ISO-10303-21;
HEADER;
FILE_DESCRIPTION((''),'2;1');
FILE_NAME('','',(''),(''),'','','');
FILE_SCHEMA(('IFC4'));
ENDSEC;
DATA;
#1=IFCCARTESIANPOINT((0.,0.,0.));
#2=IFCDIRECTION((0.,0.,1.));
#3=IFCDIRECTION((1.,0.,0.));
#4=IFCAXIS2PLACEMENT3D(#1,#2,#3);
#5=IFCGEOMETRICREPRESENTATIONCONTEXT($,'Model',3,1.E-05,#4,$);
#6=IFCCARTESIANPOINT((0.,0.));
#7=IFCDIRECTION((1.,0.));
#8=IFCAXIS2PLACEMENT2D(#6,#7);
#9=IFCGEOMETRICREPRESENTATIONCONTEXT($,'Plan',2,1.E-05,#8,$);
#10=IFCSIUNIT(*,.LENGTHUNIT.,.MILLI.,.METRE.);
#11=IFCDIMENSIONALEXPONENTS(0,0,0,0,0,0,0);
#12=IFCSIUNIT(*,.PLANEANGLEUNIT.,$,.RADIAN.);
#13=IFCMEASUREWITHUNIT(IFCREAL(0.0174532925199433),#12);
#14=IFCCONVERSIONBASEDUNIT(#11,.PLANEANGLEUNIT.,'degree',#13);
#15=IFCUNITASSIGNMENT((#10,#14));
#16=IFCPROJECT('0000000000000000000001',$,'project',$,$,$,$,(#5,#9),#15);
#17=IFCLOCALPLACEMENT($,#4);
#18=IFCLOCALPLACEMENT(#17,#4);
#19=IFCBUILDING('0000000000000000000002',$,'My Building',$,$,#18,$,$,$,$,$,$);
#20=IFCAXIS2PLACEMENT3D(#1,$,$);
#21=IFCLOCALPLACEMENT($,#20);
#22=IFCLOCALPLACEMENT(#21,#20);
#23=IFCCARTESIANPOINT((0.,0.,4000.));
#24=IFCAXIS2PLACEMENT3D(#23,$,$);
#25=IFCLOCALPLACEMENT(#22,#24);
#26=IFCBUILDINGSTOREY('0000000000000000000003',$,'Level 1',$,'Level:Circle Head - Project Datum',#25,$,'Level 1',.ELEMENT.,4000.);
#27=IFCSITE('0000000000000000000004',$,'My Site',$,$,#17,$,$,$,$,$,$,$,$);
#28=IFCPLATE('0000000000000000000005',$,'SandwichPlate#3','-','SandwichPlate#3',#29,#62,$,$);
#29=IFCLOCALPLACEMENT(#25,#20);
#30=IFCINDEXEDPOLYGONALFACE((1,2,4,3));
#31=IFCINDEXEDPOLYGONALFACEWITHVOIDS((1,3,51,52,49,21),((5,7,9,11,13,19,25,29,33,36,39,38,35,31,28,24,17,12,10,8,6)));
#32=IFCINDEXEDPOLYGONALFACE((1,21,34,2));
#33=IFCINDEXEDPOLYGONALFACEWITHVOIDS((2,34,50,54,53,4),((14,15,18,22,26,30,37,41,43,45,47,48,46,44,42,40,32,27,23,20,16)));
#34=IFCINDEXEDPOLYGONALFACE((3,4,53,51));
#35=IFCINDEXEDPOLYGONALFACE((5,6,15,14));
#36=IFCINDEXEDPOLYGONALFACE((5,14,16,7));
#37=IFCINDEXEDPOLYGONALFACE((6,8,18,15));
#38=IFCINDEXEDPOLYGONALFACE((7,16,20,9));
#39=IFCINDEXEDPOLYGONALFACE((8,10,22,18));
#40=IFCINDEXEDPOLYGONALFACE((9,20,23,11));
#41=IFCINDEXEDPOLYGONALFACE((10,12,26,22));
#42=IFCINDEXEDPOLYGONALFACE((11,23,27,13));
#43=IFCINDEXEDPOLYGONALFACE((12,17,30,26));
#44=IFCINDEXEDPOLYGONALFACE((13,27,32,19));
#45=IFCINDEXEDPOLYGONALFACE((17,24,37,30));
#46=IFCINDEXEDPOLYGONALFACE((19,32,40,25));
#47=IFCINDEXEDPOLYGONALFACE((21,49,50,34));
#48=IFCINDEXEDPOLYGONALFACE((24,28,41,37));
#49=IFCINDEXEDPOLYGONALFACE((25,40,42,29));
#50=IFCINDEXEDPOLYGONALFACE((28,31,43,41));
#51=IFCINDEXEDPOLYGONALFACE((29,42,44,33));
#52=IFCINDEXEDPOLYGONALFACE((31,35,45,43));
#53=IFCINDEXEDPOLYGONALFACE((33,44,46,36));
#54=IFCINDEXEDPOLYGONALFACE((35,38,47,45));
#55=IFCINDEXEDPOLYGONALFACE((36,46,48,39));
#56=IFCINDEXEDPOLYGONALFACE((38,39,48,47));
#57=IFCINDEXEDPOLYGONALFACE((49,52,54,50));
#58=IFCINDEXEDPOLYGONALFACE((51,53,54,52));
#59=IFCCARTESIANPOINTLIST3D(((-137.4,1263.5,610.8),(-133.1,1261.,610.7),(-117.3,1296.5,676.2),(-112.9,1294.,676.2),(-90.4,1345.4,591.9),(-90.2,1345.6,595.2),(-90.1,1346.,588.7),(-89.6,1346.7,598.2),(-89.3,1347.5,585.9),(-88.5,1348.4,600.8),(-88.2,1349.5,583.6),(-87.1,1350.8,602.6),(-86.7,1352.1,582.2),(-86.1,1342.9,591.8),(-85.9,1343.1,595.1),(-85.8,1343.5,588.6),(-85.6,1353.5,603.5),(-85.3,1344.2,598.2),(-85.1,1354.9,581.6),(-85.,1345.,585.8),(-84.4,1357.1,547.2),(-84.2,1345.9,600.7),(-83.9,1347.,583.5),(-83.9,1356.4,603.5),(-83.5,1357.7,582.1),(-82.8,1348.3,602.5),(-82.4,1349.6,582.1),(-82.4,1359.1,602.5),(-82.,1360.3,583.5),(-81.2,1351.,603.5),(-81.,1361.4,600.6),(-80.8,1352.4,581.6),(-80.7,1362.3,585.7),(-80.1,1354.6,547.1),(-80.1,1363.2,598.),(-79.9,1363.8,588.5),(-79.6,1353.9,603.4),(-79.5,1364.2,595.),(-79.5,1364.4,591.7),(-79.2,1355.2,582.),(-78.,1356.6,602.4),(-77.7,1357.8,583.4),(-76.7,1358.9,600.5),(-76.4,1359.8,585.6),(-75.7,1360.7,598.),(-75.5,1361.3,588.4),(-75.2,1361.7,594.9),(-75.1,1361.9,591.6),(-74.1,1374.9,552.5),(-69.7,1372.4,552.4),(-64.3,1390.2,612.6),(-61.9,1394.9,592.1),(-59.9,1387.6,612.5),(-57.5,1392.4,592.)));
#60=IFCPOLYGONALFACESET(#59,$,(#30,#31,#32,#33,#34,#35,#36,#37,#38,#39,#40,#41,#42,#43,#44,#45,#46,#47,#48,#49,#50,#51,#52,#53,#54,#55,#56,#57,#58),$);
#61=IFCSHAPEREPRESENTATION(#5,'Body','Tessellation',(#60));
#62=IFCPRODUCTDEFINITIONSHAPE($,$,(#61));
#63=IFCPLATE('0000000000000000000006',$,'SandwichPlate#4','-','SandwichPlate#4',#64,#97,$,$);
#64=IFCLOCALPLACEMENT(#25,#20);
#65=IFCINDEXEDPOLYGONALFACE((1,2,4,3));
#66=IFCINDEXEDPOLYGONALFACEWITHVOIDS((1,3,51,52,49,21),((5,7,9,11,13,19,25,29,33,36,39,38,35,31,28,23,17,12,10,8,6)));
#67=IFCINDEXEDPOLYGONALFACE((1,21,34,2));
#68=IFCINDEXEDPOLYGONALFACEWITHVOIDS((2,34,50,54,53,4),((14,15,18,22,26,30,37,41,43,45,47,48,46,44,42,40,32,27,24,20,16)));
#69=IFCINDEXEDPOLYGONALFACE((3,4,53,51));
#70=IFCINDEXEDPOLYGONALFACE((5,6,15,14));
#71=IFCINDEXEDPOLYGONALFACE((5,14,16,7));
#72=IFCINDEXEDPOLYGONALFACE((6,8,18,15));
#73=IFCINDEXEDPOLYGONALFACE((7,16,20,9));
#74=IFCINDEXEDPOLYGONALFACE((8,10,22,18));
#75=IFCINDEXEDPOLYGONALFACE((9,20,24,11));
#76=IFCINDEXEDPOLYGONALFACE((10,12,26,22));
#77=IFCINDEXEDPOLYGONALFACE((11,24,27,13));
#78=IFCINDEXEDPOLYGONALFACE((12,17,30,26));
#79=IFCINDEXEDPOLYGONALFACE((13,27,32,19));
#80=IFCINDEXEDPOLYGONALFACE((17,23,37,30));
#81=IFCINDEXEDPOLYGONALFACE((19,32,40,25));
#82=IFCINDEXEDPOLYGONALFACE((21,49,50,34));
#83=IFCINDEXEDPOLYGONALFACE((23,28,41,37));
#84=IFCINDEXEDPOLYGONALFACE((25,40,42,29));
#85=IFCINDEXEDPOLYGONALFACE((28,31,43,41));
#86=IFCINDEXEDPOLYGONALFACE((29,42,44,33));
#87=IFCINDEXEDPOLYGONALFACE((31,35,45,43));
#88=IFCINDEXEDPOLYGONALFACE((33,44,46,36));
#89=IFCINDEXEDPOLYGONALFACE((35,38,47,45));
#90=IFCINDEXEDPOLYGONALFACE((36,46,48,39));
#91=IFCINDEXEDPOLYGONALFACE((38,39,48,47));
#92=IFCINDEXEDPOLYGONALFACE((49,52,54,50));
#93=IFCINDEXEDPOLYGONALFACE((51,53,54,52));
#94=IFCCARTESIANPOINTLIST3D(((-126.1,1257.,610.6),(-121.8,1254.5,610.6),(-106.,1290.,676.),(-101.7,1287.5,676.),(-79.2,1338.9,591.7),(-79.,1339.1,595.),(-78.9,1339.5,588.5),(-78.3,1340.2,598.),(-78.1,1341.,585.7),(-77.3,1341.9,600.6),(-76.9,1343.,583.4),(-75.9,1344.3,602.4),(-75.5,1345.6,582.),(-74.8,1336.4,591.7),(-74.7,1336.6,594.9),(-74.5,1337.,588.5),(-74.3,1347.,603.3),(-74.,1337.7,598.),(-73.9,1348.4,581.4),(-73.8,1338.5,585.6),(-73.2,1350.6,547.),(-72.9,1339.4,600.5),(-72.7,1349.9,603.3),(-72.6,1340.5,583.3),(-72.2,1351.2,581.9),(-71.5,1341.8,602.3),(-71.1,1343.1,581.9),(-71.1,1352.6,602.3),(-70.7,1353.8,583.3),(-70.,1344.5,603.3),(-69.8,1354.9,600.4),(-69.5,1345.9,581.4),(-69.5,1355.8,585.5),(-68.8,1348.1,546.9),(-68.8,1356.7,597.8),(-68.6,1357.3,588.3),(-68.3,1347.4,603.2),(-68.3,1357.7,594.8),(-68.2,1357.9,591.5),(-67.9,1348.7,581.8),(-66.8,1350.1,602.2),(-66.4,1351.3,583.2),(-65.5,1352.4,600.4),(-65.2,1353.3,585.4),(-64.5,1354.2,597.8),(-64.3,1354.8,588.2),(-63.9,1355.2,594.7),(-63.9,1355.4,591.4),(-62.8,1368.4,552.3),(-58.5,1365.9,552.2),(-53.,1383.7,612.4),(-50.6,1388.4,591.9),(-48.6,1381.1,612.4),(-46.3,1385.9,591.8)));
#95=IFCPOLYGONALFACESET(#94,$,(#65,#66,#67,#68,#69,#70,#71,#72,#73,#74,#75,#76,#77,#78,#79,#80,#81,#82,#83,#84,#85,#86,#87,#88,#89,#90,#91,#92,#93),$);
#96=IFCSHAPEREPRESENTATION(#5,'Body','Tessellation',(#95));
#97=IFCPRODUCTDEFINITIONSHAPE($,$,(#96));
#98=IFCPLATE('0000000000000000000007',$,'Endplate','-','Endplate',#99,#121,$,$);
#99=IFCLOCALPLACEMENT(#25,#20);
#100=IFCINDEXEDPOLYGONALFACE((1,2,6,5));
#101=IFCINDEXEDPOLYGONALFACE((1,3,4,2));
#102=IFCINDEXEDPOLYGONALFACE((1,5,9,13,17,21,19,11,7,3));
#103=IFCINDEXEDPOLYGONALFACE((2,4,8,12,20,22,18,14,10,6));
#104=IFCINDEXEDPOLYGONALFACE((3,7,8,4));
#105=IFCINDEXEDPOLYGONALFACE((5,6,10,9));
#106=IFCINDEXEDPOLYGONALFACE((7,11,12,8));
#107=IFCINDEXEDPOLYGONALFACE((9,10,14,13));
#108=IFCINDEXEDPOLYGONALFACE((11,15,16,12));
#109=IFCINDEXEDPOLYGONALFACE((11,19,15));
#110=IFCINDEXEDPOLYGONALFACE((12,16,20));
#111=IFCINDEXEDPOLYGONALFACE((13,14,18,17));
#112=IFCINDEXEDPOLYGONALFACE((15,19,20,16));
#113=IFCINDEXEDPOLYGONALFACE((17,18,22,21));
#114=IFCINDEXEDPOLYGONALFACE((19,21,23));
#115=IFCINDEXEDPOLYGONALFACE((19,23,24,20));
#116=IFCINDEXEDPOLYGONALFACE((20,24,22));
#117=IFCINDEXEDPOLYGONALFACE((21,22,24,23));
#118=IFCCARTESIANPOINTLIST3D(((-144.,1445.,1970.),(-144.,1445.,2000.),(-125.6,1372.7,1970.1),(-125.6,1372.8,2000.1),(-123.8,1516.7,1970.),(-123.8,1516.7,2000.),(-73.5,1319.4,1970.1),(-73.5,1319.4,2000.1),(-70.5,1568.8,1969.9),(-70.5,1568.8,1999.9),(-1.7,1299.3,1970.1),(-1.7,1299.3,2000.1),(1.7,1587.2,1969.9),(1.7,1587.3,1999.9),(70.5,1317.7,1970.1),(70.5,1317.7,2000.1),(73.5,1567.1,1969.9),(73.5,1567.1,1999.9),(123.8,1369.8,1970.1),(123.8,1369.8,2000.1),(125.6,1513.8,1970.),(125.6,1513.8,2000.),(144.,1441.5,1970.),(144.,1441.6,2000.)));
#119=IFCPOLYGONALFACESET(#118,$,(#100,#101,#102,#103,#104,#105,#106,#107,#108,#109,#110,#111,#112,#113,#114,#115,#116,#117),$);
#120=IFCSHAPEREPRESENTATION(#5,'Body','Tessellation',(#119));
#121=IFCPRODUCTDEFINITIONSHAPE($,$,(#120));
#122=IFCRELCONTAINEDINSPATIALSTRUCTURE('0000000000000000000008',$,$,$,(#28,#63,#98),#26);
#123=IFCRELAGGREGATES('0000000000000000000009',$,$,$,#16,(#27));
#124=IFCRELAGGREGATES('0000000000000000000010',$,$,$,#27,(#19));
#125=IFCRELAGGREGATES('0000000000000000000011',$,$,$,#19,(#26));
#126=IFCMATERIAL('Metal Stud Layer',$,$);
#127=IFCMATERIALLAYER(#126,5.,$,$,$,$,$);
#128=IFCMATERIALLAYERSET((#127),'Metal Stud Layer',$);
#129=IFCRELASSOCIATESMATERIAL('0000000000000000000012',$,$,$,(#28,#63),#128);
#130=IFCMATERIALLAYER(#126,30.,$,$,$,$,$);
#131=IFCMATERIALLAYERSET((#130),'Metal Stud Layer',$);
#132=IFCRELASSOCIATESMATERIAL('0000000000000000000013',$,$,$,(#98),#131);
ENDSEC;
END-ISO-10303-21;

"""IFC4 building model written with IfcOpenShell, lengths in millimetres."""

from ifc_helpers import new_model, entity, si_unit, converted_unit, point, frame, frame_2d, origin, origin_with_axes, origin_2d_with_axis, place, context, project, spatial, polyline, circle_curve, line_curve, trimmed, segment, composite_curve, circle, outline, extrude, material, layer, layer_set, element, save


model = new_model("IFC4")

# Units and contexts
model_context = context("Model", 3, precision=1e-05, world=origin_with_axes())
plan_context = context("Plan", 2, precision=1e-05, world=origin_2d_with_axis())
ifc_project = project(units=[si_unit("LENGTHUNIT", "METRE", prefix="MILLI"), converted_unit("PLANEANGLEUNIT", "degree", entity("IfcReal", 0.0174532925199433), si_unit("PLANEANGLEUNIT", "RADIAN"), dimensions=[0, 0, 0, 0, 0, 0, 0])], contexts=[model_context, plan_context])

# Site, building, storey
site_placement = place(None, origin_with_axes())
site = spatial("IfcSite", under=ifc_project, at=site_placement, Name="My Site")
building_placement = place(site_placement, origin_with_axes())
building = spatial("IfcBuilding", under=site, at=building_placement, Name="My Building")
placement_1 = place(None, origin())
placement_2 = place(placement_1, origin())
storey_placement = place(placement_2, frame((0.0, 0.0, 4000.0)))
storey = spatial("IfcBuildingStorey", under=building, at=storey_placement, Name="Level 1", ObjectType="Level:Circle Head - Project Datum", LongName="Level 1", CompositionType="ELEMENT", Elevation=4000.0)

# Shared definitions
ifc_material_1 = material(Name="Metal Stud Layer")

# Shared definitions
ifc_layer_1 = layer(ifc_material_1, 5.0)
ifc_layer_set_1 = layer_set([ifc_layer_1], Name="Metal Stud Layer")

# Plates, openings
plate_1_placement = place(storey_placement, frame((-78.0, 1368.4, 539.6), z_axis=(0.865935, -0.499948, -0.014432), x_axis=(0.265222, 0.434531, 0.86072)))
plate_1 = element("IfcPlate", 1, at=plate_1_placement, inside=storey, material=ifc_layer_set_1, Name="SandwichPlate#3", Description="-", ObjectType="SandwichPlate#3", context=model_context, shape_type="SweptSolid", body=[
    extrude(outline(polyline([(0.0, 0.0), (76.0, 0.0), (76.0, 140.0), (0.0, 140.0), (0.0, 0.0)])), origin_with_axes(), (0.0, 0.0, 1.0), 5.0),
])
opening_1_placement = place(plate_1_placement, frame((0.0, 0.0, 0.0), z_axis=(0.0, 0.0, 1.0), x_axis=(1.0, 0.0, 0.0)))
element("IfcOpeningElement", 2, at=opening_1_placement, cuts=plate_1, ObjectType="Opening", context=model_context, shape_type="SweptSolid", body=[
    extrude(outline(polyline([(0.0, 0.0), (15.0, 0.0), (0.0, 15.0), (0.0, 0.0)])), origin(), (0.0, 0.0, 1.0), 5.0),
])
opening_2_placement = place(plate_1_placement, frame((0.0, 0.0, 0.0), z_axis=(0.0, 0.0, 1.0), x_axis=(1.0, 0.0, 0.0)))
element("IfcOpeningElement", 3, at=opening_2_placement, cuts=plate_1, ObjectType="Opening", context=model_context, shape_type="SweptSolid", body=[
    extrude(outline(polyline([(76.0, 0.0), (76.0, 15.0), (61.0, 0.0), (76.0, 0.0)])), origin(), (0.0, 0.0, 1.0), 5.0),
])
opening_3_placement = place(plate_1_placement, frame((38.0, 40.0, -0.5), z_axis=(0.0, 0.0, 1.0), x_axis=(0.0, 1.0, 0.0)))
element("IfcOpeningElement", 4, at=opening_3_placement, cuts=plate_1, ObjectType="Opening", context=model_context, shape_type="SweptSolid", body=[
    extrude(circle(Radius=11.0, at=origin_2d_with_axis()), origin(), (0.0, 0.0, 1.0), 6.0),
])
plate_2_placement = place(storey_placement, frame((-66.8, 1361.9, 539.4), z_axis=(0.865935, -0.499948, -0.014432), x_axis=(0.265222, 0.434531, 0.86072)))
plate_2 = element("IfcPlate", 5, at=plate_2_placement, inside=storey, material=ifc_layer_set_1, Name="SandwichPlate#4", Description="-", ObjectType="SandwichPlate#4", context=model_context, shape_type="SweptSolid", body=[
    extrude(outline(polyline([(0.0, 0.0), (76.0, 0.0), (76.0, 140.0), (0.0, 140.0), (0.0, 0.0)])), origin_with_axes(), (0.0, 0.0, 1.0), 5.0),
])
opening_4_placement = place(plate_2_placement, frame((0.0, 0.0, 0.0), z_axis=(0.0, 0.0, 1.0), x_axis=(1.0, 0.0, 0.0)))
element("IfcOpeningElement", 6, at=opening_4_placement, cuts=plate_2, ObjectType="Opening", context=model_context, shape_type="SweptSolid", body=[
    extrude(outline(polyline([(0.0, 0.0), (15.0, 0.0), (0.0, 15.0), (0.0, 0.0)])), origin(), (0.0, 0.0, 1.0), 5.0),
])
opening_5_placement = place(plate_2_placement, frame((0.0, 0.0, 0.0), z_axis=(0.0, 0.0, 1.0), x_axis=(1.0, 0.0, 0.0)))
element("IfcOpeningElement", 7, at=opening_5_placement, cuts=plate_2, ObjectType="Opening", context=model_context, shape_type="SweptSolid", body=[
    extrude(outline(polyline([(76.0, 0.0), (76.0, 15.0), (61.0, 0.0), (76.0, 0.0)])), origin(), (0.0, 0.0, 1.0), 5.0),
])
opening_6_placement = place(plate_2_placement, frame((38.0, 40.0, -0.5), z_axis=(0.0, 0.0, 1.0), x_axis=(0.0, 1.0, 0.0)))
element("IfcOpeningElement", 8, at=opening_6_placement, cuts=plate_2, ObjectType="Opening", context=model_context, shape_type="SweptSolid", body=[
    extrude(circle(Radius=11.0, at=origin_2d_with_axis()), origin(), (0.0, 0.0, 1.0), 6.0),
])
ifc_layer_2 = layer(ifc_material_1, 30.0)
ifc_layer_set_2 = layer_set([ifc_layer_2], Name="Metal Stud Layer")
plate_3_placement = place(storey_placement, frame((-144.0, 1445.0, 1970.0), z_axis=(0.0, 0.000811, 1.0), x_axis=(-0.011883, -0.999929, 0.000811)))
plate_3 = element("IfcPlate", 9, at=plate_3_placement, inside=storey, material=ifc_layer_set_2, Name="Endplate", Description="-", ObjectType="Endplate", context=model_context, shape_type="SweptSolid", body=[
    extrude(outline(polyline([(144.0, 0.0), (144.0, 288.0), (-144.0, 288.0), (-144.0, 0.0), (144.0, 0.0)])), origin_with_axes(), (0.0, 0.0, 1.0), 30.0),
])
opening_7_placement = place(plate_3_placement, frame((0.0, 0.0, 0.0), z_axis=(0.0, 0.0, 1.0), x_axis=(1.0, 0.0, 0.0)))
element("IfcOpeningElement", 10, at=opening_7_placement, cuts=plate_3, ObjectType="Opening", context=model_context, shape_type="SweptSolid", body=[
    extrude(outline(composite_curve([segment(trimmed(line_curve((-144.0, 288.0), (0.0, -1.0), 144.0), [point((-144.0, 288.0))], [point((-144.0, 144.0))], True, "CARTESIAN"), True, "CONTINUOUS"), segment(trimmed(circle_curve(frame_2d((0.0, 144.0), x_axis=(-1.0, 0.0)), 144.0), [point((-144.0, 144.0))], [point((0.0, 288.0))], False, "CARTESIAN"), True, "CONTINUOUS"), segment(trimmed(line_curve((0.0, 288.0), (-1.0, 0.0), 144.0), [point((0.0, 288.0))], [point((-144.0, 288.0))], True, "CARTESIAN"), True, "CONTINUOUS")], self_intersect=False)), origin(), (0.0, 0.0, 1.0), 30.0),
])
opening_8_placement = place(plate_3_placement, frame((0.0, 0.0, 0.0), z_axis=(0.0, 0.0, 1.0), x_axis=(1.0, 0.0, 0.0)))
element("IfcOpeningElement", 11, at=opening_8_placement, cuts=plate_3, ObjectType="Opening", context=model_context, shape_type="SweptSolid", body=[
    extrude(outline(composite_curve([segment(trimmed(line_curve((-144.0, 0.0), (1.0, 0.0), 144.0), [point((-144.0, 0.0))], [point((0.0, 0.0))], True, "CARTESIAN"), True, "CONTINUOUS"), segment(trimmed(circle_curve(frame_2d((0.0, 144.0), x_axis=(-1.0, 0.0)), 144.0), [point((0.0, 0.0))], [point((-144.0, 144.0))], False, "CARTESIAN"), True, "CONTINUOUS"), segment(trimmed(line_curve((-144.0, 144.0), (0.0, -1.0), 144.0), [point((-144.0, 144.0))], [point((-144.0, 0.0))], True, "CARTESIAN"), True, "CONTINUOUS")], self_intersect=False)), origin(), (0.0, 0.0, 1.0), 30.0),
])
opening_9_placement = place(plate_3_placement, frame((0.0, 0.0, 0.0), z_axis=(0.0, 0.0, 1.0), x_axis=(1.0, 0.0, 0.0)))
element("IfcOpeningElement", 12, at=opening_9_placement, cuts=plate_3, ObjectType="Opening", context=model_context, shape_type="SweptSolid", body=[
    extrude(outline(composite_curve([segment(trimmed(line_curve((144.0, 0.0), (0.0, 1.0), 144.0), [point((144.0, 0.0))], [point((144.0, 144.0))], True, "CARTESIAN"), True, "CONTINUOUS"), segment(trimmed(circle_curve(frame_2d((0.0, 144.0), x_axis=(-1.0, 0.0)), 144.0), [point((144.0, 144.0))], [point((0.0, 0.0))], False, "CARTESIAN"), True, "CONTINUOUS"), segment(trimmed(line_curve((0.0, 0.0), (1.0, 0.0), 144.0), [point((0.0, 0.0))], [point((144.0, 0.0))], True, "CARTESIAN"), True, "CONTINUOUS")], self_intersect=False)), origin(), (0.0, 0.0, 1.0), 30.0),
])
opening_10_placement = place(plate_3_placement, frame((0.0, 0.0, 0.0), z_axis=(0.0, 0.0, 1.0), x_axis=(1.0, 0.0, 0.0)))
element("IfcOpeningElement", 13, at=opening_10_placement, cuts=plate_3, ObjectType="Opening", context=model_context, shape_type="SweptSolid", body=[
    extrude(outline(composite_curve([segment(trimmed(line_curve((144.0, 288.0), (-1.0, 0.0), 144.0), [point((144.0, 288.0))], [point((0.0, 288.0))], True, "CARTESIAN"), True, "CONTINUOUS"), segment(trimmed(circle_curve(frame_2d((0.0, 144.0), x_axis=(-1.0, 0.0)), 144.0), [point((0.0, 288.0))], [point((144.0, 144.0))], False, "CARTESIAN"), True, "CONTINUOUS"), segment(trimmed(line_curve((144.0, 144.0), (0.0, 1.0), 144.0), [point((144.0, 144.0))], [point((144.0, 288.0))], True, "CARTESIAN"), True, "CONTINUOUS")], self_intersect=False)), origin(), (0.0, 0.0, 1.0), 30.0),
])

save(model, "model.ifc")
